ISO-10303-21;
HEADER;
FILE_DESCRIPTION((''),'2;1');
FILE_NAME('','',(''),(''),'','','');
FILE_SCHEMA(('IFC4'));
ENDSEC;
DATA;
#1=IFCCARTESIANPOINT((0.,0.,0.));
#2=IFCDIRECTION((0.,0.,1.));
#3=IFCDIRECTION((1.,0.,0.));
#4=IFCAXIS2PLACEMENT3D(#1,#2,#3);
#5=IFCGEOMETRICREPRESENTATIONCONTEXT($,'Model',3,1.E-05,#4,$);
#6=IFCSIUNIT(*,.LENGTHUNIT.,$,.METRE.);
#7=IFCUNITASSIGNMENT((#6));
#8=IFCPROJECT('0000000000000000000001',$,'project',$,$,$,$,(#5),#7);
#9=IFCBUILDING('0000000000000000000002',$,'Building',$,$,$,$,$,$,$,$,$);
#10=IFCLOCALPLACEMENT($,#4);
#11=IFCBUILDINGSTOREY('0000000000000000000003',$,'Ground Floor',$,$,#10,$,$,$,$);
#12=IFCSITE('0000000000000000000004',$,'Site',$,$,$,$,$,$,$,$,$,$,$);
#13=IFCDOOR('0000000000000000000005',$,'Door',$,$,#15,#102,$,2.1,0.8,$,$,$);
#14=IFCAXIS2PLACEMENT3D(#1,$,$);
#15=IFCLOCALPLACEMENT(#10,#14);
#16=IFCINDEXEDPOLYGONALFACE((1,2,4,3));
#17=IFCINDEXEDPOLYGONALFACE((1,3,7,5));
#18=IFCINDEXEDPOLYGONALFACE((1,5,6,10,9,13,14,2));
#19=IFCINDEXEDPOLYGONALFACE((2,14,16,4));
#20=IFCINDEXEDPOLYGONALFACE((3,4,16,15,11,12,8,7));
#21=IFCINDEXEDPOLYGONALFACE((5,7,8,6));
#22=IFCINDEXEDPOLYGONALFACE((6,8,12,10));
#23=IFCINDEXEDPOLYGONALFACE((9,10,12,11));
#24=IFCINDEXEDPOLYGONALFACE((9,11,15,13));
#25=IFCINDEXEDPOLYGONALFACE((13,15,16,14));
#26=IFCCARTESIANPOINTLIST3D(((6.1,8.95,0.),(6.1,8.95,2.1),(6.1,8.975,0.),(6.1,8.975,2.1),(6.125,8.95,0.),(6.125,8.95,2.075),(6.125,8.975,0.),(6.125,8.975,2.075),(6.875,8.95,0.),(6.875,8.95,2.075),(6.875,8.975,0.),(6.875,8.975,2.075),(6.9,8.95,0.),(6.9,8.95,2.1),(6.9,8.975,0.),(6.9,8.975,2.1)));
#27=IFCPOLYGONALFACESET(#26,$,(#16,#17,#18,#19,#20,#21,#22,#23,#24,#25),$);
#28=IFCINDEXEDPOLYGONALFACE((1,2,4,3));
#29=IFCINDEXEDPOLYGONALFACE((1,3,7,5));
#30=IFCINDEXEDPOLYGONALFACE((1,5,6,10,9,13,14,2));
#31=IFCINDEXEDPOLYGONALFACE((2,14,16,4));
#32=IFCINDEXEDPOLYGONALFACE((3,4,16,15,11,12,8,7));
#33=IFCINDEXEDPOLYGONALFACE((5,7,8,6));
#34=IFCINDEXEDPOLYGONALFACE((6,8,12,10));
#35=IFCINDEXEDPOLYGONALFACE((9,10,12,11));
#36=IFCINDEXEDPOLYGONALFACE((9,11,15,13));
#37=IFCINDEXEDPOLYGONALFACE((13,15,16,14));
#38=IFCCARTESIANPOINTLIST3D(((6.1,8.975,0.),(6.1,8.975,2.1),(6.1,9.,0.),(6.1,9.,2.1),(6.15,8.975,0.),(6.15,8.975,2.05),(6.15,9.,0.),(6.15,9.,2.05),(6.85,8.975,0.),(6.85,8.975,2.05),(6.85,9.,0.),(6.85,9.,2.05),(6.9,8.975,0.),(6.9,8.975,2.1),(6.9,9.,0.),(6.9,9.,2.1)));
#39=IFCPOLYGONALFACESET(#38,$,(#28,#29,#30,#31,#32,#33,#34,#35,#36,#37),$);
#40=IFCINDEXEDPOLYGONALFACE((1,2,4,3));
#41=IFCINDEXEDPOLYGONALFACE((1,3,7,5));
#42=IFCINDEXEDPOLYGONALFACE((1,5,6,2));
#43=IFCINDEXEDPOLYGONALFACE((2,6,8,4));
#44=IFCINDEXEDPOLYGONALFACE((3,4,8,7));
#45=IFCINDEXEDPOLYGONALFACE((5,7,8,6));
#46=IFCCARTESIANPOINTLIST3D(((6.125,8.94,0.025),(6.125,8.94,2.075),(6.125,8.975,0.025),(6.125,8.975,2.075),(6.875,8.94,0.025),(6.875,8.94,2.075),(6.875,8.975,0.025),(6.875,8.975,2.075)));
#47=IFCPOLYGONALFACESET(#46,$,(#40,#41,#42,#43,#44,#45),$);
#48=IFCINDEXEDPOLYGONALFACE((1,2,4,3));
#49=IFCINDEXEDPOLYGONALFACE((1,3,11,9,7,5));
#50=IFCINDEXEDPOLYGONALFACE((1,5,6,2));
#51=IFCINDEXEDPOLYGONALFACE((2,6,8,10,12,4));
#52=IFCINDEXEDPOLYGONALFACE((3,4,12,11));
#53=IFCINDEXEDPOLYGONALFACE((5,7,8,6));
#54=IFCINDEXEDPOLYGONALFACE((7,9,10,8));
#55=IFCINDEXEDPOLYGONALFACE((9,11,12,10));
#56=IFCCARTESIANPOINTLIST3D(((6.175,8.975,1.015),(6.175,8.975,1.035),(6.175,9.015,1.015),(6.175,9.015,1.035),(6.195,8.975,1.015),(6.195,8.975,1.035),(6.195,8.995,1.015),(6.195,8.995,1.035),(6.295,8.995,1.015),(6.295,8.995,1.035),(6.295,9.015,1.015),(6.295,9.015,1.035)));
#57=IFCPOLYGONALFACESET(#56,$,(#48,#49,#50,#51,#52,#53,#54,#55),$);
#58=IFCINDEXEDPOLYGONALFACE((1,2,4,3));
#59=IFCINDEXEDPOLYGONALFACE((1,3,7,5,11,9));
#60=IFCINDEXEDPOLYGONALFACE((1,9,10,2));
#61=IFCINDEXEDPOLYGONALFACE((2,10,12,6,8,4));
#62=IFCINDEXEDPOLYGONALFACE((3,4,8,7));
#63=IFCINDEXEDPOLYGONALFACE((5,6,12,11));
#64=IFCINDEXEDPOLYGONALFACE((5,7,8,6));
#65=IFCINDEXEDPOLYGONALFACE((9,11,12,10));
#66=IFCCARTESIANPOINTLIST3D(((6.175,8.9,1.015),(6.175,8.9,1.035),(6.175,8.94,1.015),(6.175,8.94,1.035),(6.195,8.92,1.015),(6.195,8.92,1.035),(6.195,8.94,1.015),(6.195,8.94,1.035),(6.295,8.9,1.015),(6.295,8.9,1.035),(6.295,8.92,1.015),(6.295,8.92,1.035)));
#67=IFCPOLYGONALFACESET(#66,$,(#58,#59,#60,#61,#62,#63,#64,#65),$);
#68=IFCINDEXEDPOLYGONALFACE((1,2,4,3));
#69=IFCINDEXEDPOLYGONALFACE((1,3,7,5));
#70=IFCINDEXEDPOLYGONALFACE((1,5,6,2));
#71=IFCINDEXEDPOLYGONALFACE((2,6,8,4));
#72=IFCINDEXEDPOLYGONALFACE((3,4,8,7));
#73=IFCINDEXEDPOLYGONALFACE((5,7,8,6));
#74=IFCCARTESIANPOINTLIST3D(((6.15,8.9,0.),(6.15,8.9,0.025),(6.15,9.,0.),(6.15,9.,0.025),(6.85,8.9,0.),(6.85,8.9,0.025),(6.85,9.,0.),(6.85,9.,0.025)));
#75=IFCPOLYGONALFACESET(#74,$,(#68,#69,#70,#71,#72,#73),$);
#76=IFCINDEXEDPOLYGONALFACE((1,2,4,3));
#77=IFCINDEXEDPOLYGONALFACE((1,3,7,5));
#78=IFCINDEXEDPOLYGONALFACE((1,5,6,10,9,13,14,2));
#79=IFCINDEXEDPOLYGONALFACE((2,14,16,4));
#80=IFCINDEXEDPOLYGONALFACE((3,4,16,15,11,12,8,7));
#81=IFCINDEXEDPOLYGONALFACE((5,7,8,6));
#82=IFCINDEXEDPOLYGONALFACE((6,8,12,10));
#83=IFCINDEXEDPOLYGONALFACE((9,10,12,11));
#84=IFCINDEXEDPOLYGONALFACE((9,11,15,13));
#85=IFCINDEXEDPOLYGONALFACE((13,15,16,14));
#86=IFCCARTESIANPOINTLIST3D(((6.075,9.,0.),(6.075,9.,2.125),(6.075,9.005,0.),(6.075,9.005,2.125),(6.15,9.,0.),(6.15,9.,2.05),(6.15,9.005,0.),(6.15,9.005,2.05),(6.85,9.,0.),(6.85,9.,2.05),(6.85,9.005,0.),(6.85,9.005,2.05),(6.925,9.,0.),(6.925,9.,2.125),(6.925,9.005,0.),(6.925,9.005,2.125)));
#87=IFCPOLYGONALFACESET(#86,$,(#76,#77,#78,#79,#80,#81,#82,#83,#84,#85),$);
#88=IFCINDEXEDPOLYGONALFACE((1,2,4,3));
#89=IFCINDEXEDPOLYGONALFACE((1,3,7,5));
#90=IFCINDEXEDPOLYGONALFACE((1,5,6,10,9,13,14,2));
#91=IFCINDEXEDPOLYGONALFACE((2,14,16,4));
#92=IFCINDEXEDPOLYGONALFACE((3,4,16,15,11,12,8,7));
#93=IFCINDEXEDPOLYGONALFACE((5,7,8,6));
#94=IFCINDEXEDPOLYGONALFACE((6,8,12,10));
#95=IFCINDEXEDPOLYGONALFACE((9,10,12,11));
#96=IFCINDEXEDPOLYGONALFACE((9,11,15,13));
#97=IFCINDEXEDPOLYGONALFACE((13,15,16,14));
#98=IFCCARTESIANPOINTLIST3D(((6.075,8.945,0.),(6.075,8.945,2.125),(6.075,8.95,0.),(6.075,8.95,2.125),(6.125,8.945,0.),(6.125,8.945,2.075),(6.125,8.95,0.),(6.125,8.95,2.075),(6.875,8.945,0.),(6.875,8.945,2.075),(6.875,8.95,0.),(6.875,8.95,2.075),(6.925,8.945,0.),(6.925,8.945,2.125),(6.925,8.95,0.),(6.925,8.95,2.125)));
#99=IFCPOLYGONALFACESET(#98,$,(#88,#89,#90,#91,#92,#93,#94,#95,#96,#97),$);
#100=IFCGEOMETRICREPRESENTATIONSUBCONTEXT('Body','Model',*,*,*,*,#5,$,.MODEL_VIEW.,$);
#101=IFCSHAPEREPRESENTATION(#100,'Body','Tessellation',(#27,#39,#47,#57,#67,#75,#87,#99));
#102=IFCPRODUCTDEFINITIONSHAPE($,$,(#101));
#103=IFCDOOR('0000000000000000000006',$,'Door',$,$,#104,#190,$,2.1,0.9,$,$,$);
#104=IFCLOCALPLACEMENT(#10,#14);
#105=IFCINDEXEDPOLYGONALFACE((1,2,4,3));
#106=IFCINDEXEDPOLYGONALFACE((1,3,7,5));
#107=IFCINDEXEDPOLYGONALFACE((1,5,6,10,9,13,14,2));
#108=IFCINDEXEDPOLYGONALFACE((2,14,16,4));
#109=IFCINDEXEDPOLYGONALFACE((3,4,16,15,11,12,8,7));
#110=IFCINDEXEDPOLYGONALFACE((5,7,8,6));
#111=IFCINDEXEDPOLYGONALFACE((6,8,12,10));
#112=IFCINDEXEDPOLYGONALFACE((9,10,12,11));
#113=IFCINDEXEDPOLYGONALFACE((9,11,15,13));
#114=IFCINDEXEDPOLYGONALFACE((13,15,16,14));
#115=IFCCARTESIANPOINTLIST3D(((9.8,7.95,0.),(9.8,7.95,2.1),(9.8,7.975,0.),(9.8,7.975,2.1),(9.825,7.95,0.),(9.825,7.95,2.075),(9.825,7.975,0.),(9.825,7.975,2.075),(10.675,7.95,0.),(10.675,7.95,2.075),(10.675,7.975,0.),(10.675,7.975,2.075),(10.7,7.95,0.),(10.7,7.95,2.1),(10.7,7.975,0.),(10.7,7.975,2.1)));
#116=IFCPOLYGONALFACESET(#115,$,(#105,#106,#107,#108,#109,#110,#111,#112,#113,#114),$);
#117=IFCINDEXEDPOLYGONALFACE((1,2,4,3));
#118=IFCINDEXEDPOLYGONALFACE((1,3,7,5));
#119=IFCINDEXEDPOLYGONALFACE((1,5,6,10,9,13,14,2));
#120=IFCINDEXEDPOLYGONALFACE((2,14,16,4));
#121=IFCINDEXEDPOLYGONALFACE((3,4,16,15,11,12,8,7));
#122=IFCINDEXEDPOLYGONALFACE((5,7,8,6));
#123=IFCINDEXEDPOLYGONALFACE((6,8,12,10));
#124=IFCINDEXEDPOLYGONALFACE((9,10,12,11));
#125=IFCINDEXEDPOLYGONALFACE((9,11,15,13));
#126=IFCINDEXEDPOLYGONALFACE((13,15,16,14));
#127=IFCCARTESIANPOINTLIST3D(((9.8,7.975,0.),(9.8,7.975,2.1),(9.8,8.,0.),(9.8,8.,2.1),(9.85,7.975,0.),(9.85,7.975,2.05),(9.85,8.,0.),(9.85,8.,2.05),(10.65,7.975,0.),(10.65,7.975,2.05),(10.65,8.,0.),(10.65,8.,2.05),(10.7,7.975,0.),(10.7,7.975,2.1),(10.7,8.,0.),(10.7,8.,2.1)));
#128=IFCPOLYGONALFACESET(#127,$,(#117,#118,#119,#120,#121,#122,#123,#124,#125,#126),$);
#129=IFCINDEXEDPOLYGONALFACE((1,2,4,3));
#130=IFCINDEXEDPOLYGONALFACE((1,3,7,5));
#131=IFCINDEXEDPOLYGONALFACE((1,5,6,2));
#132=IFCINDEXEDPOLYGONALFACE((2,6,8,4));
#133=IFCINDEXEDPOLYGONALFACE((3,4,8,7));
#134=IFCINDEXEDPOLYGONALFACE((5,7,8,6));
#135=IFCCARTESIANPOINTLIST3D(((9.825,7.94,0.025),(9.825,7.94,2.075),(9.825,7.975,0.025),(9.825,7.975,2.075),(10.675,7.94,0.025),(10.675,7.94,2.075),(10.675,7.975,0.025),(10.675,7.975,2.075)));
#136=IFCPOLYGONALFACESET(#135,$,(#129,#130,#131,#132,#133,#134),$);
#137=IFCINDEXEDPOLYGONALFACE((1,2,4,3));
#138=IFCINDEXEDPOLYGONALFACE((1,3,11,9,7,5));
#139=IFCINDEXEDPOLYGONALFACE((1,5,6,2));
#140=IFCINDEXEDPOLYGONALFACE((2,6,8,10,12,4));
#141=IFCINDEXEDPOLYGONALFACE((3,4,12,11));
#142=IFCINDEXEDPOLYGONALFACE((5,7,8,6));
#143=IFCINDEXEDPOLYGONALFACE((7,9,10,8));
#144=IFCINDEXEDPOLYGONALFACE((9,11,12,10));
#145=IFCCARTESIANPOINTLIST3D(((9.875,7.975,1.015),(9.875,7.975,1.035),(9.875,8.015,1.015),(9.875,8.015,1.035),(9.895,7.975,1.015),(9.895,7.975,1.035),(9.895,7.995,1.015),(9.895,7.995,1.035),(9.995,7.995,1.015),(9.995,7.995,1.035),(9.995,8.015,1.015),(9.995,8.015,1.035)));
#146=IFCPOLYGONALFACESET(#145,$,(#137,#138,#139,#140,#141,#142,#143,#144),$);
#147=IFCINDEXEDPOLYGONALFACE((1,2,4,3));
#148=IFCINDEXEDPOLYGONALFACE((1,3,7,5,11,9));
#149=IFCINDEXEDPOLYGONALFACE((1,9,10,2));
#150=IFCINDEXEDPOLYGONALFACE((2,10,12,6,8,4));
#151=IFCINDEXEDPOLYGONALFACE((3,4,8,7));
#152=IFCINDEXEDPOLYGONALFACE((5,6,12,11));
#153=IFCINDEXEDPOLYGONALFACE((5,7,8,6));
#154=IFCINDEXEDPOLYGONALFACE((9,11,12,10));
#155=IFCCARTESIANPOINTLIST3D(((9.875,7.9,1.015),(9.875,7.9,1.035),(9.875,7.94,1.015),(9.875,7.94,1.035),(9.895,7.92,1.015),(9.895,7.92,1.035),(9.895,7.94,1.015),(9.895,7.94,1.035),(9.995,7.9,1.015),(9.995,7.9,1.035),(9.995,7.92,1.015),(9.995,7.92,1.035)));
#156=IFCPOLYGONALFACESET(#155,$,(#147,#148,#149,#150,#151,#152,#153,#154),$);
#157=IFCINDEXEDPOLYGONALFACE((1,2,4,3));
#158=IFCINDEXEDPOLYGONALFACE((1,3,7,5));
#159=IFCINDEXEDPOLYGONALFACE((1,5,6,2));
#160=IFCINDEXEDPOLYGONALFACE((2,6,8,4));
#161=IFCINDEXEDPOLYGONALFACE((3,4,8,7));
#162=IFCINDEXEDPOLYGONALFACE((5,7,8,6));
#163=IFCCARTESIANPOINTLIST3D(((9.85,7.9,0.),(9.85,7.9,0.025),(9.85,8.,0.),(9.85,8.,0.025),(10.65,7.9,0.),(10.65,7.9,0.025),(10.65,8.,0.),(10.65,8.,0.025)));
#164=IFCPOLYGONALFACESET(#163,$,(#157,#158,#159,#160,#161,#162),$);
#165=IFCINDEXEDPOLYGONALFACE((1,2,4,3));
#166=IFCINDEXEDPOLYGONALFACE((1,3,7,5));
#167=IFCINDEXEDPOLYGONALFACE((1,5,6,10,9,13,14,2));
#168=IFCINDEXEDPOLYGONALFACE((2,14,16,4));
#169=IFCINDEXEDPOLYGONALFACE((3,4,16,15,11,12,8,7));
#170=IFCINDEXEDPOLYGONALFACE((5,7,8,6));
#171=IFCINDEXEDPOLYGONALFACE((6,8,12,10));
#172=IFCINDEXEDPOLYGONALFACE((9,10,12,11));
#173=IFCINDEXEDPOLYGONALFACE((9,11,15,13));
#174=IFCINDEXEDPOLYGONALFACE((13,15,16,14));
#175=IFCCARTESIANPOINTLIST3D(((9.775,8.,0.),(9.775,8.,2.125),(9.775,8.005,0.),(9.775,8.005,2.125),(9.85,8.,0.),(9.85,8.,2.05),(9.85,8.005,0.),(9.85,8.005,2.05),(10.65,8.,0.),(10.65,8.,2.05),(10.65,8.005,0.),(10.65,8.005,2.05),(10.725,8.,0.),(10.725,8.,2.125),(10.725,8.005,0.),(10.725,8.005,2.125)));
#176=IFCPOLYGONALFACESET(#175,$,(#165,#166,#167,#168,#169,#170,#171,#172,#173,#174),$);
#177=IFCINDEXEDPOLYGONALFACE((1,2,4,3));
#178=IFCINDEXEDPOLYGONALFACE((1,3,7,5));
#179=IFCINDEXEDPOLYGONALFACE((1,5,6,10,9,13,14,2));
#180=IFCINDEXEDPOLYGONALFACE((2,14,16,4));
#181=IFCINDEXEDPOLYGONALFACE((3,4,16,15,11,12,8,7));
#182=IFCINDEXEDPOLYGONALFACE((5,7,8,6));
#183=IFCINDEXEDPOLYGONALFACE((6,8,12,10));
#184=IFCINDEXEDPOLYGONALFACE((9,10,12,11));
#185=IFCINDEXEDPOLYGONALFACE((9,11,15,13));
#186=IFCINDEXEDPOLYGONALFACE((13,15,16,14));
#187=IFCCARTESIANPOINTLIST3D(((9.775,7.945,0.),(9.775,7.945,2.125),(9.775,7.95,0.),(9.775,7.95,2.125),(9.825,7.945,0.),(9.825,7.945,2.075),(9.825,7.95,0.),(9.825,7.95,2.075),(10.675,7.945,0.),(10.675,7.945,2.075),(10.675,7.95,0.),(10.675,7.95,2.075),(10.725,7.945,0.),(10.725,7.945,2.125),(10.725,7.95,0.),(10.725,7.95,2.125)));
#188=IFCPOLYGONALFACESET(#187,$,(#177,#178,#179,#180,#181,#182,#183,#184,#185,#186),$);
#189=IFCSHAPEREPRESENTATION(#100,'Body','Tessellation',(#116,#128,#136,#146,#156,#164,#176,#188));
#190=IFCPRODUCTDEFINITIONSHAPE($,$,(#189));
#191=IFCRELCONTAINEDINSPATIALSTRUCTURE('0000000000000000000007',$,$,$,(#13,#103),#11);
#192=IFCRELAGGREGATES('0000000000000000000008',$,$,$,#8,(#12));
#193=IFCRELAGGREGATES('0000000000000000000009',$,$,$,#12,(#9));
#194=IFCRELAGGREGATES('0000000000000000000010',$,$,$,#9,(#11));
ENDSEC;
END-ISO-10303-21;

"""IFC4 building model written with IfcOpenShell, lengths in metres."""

from ifc_helpers import new_model, si_unit, frame, origin_with_axes, place, context, subcontext, project, spatial, line, indexed_curve, outline, extrude, element, save


model = new_model("IFC4")

# Units and contexts
model_context = context("Model", 3, precision=1e-05, world=origin_with_axes())
body_context = subcontext(model_context, "Body", "Model", "MODEL_VIEW")
ifc_project = project(units=[si_unit("LENGTHUNIT", "METRE")], contexts=[model_context])

# Site, building, storey
site = spatial("IfcSite", under=ifc_project, Name="Site")
building = spatial("IfcBuilding", under=site, Name="Building")
storey_placement = place(None, origin_with_axes())
storey = spatial("IfcBuildingStorey", under=building, at=storey_placement, Name="Ground Floor")

# Doors
door_1_placement = place(storey_placement, frame((6.9, 9.0, 0.0), z_axis=(0.0, 0.0, 1.0), x_axis=(-1.0, 0.0, 0.0)))
element("IfcDoor", 1, at=door_1_placement, inside=storey, Name="Door", OverallHeight=2.1, OverallWidth=0.8, context=body_context, shape_type="SweptSolid", body=[
    extrude(outline(indexed_curve([(0.0, 0.0), (0.0, 2.1), (0.8, 2.1), (0.8, 0.0), (0.775, 0.0), (0.775, 2.075), (0.025, 2.075), (0.025, 0.0)], segments=[line(1, 2, 3, 4, 5, 6, 7, 8, 1)])), frame((0.0, 0.025, 0.0), z_axis=(0.0, -1.0, 0.0), x_axis=(1.0, 0.0, 0.0)), (0.0, 0.0, -1.0), 0.025),
    extrude(outline(indexed_curve([(0.0, 0.0), (0.0, 2.1), (0.8, 2.1), (0.8, 0.0), (0.75, 0.0), (0.75, 2.05), (0.05, 2.05), (0.05, 0.0)], segments=[line(1, 2, 3, 4, 5, 6, 7, 8, 1)])), frame((0.0, 0.0, 0.0), z_axis=(0.0, -1.0, 0.0), x_axis=(1.0, 0.0, 0.0)), (0.0, 0.0, -1.0), 0.025),
    extrude(outline(indexed_curve([(0.0, 0.0), (0.75, 0.0), (0.75, 0.035), (0.0, 0.035)], segments=[line(1, 2, 3, 4, 1)])), frame((0.025, 0.025, 0.025), z_axis=(0.0, 0.0, 1.0), x_axis=(1.0, 0.0, 0.0)), (0.0, 0.0, 1.0), 2.05),
    extrude(outline(indexed_curve([(0.0, 0.0), (0.0, -0.04), (-0.12, -0.04), (-0.12, -0.02), (-0.02, -0.02), (-0.02, 0.0)], segments=[line(1, 2, 3, 4, 5, 6, 1)])), frame((0.725, 0.025, 1.015), z_axis=(0.0, 0.0, 1.0), x_axis=(1.0, 0.0, 0.0)), (0.0, 0.0, 1.0), 0.02),
    extrude(outline(indexed_curve([(0.0, 0.0), (0.0, 0.04), (-0.12, 0.04), (-0.12, 0.02), (-0.02, 0.02), (-0.02, 0.0)], segments=[line(1, 2, 3, 4, 5, 6, 1)])), frame((0.725, 0.06, 1.015), z_axis=(0.0, 0.0, 1.0), x_axis=(1.0, 0.0, 0.0)), (0.0, 0.0, 1.0), 0.02),
    extrude(outline(indexed_curve([(0.0, 0.0), (0.7, 0.0), (0.7, 0.1), (0.0, 0.1)], segments=[line(1, 2, 3, 4, 1)])), frame((0.05, 0.0, 0.0), z_axis=(0.0, 0.0, 1.0), x_axis=(1.0, 0.0, 0.0)), (0.0, 0.0, 1.0), 0.025),
    extrude(outline(indexed_curve([(0.0, 0.0), (0.0, 2.125), (0.85, 2.125), (0.85, 0.0), (0.775, 0.0), (0.775, 2.05), (0.075, 2.05), (0.075, 0.0)], segments=[line(1, 2, 3, 4, 5, 6, 7, 8, 1)])), frame((-0.025, -0.005, 0.0), z_axis=(0.0, -1.0, 0.0), x_axis=(1.0, 0.0, 0.0)), (0.0, 0.0, -1.0), 0.005),
    extrude(outline(indexed_curve([(0.0, 0.0), (0.0, 2.125), (0.85, 2.125), (0.85, 0.0), (0.8, 0.0), (0.8, 2.075), (0.05, 2.075), (0.05, 0.0)], segments=[line(1, 2, 3, 4, 5, 6, 7, 8, 1)])), frame((-0.025, 0.05, 0.0), z_axis=(0.0, -1.0, 0.0), x_axis=(1.0, 0.0, 0.0)), (0.0, 0.0, -1.0), 0.005),
])
door_2_placement = place(storey_placement, frame((10.7, 8.0, 0.0), z_axis=(0.0, 0.0, 1.0), x_axis=(-1.0, 0.0, 0.0)))
element("IfcDoor", 2, at=door_2_placement, inside=storey, Name="Door", OverallHeight=2.1, OverallWidth=0.9, context=body_context, shape_type="SweptSolid", body=[
    extrude(outline(indexed_curve([(0.0, 0.0), (0.0, 2.1), (0.9, 2.1), (0.9, 0.0), (0.875, 0.0), (0.875, 2.075), (0.025, 2.075), (0.025, 0.0)], segments=[line(1, 2, 3, 4, 5, 6, 7, 8, 1)])), frame((0.0, 0.025, 0.0), z_axis=(0.0, -1.0, 0.0), x_axis=(1.0, 0.0, 0.0)), (0.0, 0.0, -1.0), 0.025),
    extrude(outline(indexed_curve([(0.0, 0.0), (0.0, 2.1), (0.9, 2.1), (0.9, 0.0), (0.85, 0.0), (0.85, 2.05), (0.05, 2.05), (0.05, 0.0)], segments=[line(1, 2, 3, 4, 5, 6, 7, 8, 1)])), frame((0.0, 0.0, 0.0), z_axis=(0.0, -1.0, 0.0), x_axis=(1.0, 0.0, 0.0)), (0.0, 0.0, -1.0), 0.025),
    extrude(outline(indexed_curve([(0.0, 0.0), (0.85, 0.0), (0.85, 0.035), (0.0, 0.035)], segments=[line(1, 2, 3, 4, 1)])), frame((0.025, 0.025, 0.025), z_axis=(0.0, 0.0, 1.0), x_axis=(1.0, 0.0, 0.0)), (0.0, 0.0, 1.0), 2.05),
    extrude(outline(indexed_curve([(0.0, 0.0), (0.0, -0.04), (-0.12, -0.04), (-0.12, -0.02), (-0.02, -0.02), (-0.02, 0.0)], segments=[line(1, 2, 3, 4, 5, 6, 1)])), frame((0.825, 0.025, 1.015), z_axis=(0.0, 0.0, 1.0), x_axis=(1.0, 0.0, 0.0)), (0.0, 0.0, 1.0), 0.02),
    extrude(outline(indexed_curve([(0.0, 0.0), (0.0, 0.04), (-0.12, 0.04), (-0.12, 0.02), (-0.02, 0.02), (-0.02, 0.0)], segments=[line(1, 2, 3, 4, 5, 6, 1)])), frame((0.825, 0.06, 1.015), z_axis=(0.0, 0.0, 1.0), x_axis=(1.0, 0.0, 0.0)), (0.0, 0.0, 1.0), 0.02),
    extrude(outline(indexed_curve([(0.0, 0.0), (0.8, 0.0), (0.8, 0.1), (0.0, 0.1)], segments=[line(1, 2, 3, 4, 1)])), frame((0.05, 0.0, 0.0), z_axis=(0.0, 0.0, 1.0), x_axis=(1.0, 0.0, 0.0)), (0.0, 0.0, 1.0), 0.025),
    extrude(outline(indexed_curve([(0.0, 0.0), (0.0, 2.125), (0.95, 2.125), (0.95, 0.0), (0.875, 0.0), (0.875, 2.05), (0.075, 2.05), (0.075, 0.0)], segments=[line(1, 2, 3, 4, 5, 6, 7, 8, 1)])), frame((-0.025, -0.005, 0.0), z_axis=(0.0, -1.0, 0.0), x_axis=(1.0, 0.0, 0.0)), (0.0, 0.0, -1.0), 0.005),
    extrude(outline(indexed_curve([(0.0, 0.0), (0.0, 2.125), (0.95, 2.125), (0.95, 0.0), (0.9, 0.0), (0.9, 2.075), (0.05, 2.075), (0.05, 0.0)], segments=[line(1, 2, 3, 4, 5, 6, 7, 8, 1)])), frame((-0.025, 0.05, 0.0), z_axis=(0.0, -1.0, 0.0), x_axis=(1.0, 0.0, 0.0)), (0.0, 0.0, -1.0), 0.005),
])

save(model, "model.ifc")
